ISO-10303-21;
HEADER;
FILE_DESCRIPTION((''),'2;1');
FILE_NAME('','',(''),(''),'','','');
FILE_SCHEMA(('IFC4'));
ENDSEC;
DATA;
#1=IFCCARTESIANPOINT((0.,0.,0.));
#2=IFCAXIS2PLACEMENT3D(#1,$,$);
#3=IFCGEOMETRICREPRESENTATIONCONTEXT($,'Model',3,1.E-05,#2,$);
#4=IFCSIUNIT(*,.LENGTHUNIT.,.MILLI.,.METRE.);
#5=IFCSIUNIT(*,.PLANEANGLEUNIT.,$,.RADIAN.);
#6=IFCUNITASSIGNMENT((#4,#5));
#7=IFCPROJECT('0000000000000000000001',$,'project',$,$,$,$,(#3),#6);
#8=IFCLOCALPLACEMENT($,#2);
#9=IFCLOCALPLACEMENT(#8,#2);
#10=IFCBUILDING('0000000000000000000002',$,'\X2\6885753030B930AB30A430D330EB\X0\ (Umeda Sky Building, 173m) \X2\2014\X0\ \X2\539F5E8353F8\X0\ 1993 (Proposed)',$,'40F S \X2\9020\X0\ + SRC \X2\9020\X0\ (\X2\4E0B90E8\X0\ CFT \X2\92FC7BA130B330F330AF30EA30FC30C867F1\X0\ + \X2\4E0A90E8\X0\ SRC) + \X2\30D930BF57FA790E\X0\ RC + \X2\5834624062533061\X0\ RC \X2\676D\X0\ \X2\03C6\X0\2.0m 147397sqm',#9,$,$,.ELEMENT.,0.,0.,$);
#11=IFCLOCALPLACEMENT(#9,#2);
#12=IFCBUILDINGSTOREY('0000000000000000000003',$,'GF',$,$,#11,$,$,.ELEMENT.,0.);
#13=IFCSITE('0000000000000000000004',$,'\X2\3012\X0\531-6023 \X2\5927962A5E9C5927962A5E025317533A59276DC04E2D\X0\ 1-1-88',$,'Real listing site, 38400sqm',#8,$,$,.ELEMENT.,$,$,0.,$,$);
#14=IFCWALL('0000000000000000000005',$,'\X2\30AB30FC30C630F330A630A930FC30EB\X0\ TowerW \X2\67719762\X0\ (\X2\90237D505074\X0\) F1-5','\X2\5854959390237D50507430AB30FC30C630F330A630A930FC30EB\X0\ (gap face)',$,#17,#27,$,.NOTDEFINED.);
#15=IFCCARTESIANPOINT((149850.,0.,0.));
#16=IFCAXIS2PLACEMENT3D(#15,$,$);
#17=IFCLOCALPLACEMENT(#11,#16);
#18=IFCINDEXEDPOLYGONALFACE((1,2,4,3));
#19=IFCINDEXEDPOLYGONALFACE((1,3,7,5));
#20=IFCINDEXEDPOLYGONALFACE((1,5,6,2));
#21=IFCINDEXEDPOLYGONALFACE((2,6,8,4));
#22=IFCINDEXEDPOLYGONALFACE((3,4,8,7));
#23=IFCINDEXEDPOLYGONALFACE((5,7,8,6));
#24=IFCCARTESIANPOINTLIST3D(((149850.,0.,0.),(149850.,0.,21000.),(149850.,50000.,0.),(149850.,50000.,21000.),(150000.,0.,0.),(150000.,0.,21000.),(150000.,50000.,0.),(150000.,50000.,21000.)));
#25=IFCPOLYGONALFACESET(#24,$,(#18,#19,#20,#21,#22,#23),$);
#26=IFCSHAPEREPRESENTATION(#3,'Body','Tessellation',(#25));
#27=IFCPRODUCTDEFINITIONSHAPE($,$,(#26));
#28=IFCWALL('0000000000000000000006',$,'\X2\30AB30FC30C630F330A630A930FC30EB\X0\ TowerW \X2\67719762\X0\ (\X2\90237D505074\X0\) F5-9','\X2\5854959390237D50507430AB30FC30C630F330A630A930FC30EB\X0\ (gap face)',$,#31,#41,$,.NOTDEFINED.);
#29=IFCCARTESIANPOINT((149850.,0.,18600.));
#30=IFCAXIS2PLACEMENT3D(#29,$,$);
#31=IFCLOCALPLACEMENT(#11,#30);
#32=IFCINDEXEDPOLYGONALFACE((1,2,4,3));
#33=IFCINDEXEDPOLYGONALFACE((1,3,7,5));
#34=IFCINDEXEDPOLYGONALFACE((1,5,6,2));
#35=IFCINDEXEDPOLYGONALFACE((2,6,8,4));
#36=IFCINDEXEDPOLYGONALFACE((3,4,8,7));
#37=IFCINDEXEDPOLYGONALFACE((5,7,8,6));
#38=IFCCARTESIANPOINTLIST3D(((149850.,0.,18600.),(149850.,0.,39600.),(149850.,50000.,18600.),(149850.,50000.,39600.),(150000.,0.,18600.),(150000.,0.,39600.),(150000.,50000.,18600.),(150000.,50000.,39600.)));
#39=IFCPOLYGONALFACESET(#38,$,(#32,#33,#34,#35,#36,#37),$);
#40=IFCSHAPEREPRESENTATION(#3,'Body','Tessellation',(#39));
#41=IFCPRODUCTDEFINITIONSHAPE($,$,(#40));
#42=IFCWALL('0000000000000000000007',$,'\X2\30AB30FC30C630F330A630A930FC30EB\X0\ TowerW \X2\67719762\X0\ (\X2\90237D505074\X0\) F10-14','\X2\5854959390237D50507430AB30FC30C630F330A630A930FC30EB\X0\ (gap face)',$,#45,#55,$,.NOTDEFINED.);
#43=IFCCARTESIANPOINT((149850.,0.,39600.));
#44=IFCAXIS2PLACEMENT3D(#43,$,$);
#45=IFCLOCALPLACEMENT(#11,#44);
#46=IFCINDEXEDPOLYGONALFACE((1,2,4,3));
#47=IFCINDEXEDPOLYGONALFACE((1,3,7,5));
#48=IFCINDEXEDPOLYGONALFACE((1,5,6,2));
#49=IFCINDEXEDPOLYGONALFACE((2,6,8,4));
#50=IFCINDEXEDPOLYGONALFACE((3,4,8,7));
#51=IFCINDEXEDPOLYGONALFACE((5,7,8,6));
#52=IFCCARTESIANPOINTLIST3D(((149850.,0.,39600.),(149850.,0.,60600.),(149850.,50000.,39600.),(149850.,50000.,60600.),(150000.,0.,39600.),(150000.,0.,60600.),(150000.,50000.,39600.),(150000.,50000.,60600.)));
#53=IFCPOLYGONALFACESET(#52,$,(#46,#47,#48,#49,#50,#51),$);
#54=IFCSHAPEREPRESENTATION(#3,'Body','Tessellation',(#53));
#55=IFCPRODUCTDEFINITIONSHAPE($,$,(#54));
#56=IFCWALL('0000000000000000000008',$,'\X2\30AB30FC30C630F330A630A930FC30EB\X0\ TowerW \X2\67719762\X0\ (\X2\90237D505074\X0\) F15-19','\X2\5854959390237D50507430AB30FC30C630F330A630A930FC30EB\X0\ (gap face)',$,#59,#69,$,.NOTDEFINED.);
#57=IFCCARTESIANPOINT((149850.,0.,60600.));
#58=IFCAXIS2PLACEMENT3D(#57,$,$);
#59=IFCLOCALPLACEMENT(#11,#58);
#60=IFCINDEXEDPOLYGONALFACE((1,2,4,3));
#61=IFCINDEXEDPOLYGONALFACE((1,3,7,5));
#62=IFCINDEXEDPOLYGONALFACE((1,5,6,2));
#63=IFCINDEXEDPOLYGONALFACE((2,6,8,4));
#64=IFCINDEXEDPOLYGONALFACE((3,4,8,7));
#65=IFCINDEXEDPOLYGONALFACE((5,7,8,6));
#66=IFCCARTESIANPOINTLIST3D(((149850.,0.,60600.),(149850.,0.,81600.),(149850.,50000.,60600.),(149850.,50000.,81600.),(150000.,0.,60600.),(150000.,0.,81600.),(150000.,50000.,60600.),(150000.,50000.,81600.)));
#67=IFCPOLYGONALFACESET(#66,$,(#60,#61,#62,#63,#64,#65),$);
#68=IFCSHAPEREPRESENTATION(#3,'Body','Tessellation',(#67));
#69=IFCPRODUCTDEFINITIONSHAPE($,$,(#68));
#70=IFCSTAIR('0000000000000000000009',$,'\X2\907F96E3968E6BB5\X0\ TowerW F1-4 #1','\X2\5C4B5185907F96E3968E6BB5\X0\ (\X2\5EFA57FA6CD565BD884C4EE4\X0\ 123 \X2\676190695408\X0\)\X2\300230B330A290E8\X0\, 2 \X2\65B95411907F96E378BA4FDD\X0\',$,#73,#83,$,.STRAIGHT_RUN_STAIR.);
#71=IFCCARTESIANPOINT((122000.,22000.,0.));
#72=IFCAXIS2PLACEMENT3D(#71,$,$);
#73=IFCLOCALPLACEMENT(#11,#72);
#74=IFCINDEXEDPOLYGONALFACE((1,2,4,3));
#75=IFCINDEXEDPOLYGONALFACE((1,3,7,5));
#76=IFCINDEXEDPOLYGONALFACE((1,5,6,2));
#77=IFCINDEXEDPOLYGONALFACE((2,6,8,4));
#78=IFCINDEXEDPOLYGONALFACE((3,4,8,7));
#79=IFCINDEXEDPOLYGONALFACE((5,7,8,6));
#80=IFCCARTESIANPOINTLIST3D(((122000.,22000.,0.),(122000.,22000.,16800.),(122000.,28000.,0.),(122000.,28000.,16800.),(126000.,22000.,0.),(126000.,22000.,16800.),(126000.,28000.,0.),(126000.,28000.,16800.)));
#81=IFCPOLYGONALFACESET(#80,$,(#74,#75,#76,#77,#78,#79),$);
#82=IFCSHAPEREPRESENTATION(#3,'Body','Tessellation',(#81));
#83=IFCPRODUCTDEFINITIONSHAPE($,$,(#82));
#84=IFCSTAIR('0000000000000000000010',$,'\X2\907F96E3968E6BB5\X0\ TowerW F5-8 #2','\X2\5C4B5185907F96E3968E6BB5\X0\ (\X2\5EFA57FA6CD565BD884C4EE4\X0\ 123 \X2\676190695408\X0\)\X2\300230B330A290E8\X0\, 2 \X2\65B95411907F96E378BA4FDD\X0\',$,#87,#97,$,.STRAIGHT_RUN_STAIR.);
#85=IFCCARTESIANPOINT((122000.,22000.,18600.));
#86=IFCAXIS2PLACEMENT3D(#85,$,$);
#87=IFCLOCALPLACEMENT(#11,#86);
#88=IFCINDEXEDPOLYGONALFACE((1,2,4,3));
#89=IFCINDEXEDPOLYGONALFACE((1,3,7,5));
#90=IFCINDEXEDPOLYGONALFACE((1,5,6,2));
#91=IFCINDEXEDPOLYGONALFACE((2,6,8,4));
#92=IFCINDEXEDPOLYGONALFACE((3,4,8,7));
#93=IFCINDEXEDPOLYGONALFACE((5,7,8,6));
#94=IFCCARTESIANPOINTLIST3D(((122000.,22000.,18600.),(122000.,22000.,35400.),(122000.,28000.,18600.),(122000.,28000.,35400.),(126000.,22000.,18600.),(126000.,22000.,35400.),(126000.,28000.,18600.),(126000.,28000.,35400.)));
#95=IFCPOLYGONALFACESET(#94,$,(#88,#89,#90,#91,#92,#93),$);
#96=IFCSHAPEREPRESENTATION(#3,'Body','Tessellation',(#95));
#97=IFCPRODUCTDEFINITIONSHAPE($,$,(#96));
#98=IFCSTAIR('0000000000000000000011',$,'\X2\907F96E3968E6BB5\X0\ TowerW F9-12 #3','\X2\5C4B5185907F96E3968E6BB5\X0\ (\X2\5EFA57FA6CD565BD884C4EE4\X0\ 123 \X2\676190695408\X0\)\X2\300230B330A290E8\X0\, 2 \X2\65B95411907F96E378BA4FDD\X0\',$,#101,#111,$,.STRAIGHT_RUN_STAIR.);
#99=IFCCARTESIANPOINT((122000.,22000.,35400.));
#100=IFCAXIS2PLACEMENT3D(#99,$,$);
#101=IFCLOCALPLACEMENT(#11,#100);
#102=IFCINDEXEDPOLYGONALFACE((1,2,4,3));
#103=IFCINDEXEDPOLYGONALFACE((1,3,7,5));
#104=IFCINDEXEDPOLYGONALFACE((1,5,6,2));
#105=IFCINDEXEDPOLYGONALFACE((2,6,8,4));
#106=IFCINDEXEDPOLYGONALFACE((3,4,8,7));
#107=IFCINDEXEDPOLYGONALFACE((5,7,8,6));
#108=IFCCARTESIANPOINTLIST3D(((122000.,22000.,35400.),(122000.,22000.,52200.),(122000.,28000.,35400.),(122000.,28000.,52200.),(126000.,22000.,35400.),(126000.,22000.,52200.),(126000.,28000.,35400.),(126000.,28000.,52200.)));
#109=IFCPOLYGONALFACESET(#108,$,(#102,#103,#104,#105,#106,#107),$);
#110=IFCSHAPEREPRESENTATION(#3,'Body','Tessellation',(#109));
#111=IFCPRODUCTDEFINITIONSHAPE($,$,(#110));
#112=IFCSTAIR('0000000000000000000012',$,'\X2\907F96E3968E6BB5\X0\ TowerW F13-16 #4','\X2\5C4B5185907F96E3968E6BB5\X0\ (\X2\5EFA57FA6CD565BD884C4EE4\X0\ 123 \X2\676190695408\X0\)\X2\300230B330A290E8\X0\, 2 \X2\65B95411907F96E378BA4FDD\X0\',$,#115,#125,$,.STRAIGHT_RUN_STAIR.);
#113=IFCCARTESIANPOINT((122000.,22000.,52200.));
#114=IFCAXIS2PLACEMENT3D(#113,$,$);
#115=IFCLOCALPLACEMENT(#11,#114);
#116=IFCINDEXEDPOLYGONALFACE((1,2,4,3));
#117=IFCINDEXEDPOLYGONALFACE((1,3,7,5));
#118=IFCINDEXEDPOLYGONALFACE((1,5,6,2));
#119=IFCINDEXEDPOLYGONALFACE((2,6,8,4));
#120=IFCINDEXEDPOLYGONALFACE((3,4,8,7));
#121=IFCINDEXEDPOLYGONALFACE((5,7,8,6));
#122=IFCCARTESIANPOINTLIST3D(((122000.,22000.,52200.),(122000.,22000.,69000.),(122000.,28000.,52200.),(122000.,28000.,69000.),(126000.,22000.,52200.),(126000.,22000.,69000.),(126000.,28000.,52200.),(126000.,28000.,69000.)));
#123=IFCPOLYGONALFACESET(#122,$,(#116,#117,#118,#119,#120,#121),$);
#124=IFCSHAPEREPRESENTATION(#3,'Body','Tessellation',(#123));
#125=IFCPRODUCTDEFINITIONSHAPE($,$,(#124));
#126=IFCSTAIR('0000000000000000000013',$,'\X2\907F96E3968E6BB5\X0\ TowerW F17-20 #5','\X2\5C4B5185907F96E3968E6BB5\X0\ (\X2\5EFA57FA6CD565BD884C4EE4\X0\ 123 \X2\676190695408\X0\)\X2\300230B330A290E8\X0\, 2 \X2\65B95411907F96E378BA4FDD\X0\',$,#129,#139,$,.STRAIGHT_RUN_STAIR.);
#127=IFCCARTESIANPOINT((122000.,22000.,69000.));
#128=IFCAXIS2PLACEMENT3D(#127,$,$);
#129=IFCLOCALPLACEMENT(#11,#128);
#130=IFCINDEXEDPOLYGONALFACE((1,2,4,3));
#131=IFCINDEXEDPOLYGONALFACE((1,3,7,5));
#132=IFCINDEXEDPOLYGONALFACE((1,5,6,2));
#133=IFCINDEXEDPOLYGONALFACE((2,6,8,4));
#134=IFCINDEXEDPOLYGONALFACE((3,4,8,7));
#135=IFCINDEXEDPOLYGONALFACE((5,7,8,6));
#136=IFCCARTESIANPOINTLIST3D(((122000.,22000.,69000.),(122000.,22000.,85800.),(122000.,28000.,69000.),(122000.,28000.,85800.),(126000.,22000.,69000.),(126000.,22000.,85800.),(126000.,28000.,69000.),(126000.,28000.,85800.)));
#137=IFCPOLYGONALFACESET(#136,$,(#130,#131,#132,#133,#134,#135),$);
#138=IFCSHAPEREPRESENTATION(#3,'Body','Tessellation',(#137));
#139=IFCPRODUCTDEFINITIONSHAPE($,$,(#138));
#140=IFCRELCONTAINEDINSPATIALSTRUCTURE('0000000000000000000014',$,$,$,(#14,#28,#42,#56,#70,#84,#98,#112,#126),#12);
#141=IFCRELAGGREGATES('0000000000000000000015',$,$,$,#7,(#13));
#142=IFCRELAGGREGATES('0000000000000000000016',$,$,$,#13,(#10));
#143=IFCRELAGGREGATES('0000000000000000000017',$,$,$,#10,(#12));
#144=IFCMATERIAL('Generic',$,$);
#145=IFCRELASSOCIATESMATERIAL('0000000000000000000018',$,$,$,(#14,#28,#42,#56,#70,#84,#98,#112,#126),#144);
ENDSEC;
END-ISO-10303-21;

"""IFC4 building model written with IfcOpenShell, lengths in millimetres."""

from ifc_helpers import new_model, si_unit, frame, frame_2d, origin, place, context, project, spatial, rectangle, extrude, material, element, save


model = new_model("IFC4")

# Units and contexts
model_context = context("Model", 3, precision=1e-05, world=origin())
ifc_project = project(units=[si_unit("LENGTHUNIT", "METRE", prefix="MILLI"), si_unit("PLANEANGLEUNIT", "RADIAN")], contexts=[model_context])

# Site, building, storey
site_placement = place(None, origin())
site = spatial("IfcSite", under=ifc_project, at=site_placement, Name="〒531-6023 大阪府大阪市北区大淀中 1-1-88", ObjectType="Real listing site, 38400sqm", CompositionType="ELEMENT", RefElevation=0.0)
building_placement = place(site_placement, origin())
building = spatial("IfcBuilding", under=site, at=building_placement, Name="梅田スカイビル (Umeda Sky Building, 173m) — 原広司 1993 (Proposed)", ObjectType="40F S 造 + SRC 造 (下部 CFT 鋼管コンクリート柱 + 上部 SRC) + ベタ基礎 RC + 場所打ち RC 杭 φ2.0m 147397sqm", CompositionType="ELEMENT", ElevationOfRefHeight=0.0, ElevationOfTerrain=0.0)
storey_placement = place(building_placement, origin())
storey = spatial("IfcBuildingStorey", under=building, at=storey_placement, Name="GF", CompositionType="ELEMENT", Elevation=0.0)

# Walls
ifc_material_1 = material(Name="Generic")
wall_1_placement = place(storey_placement, frame((149850.0, 0.0, 0.0)))
element("IfcWall", 1, at=wall_1_placement, inside=storey, material=ifc_material_1, Name="カーテンウォール TowerW 東面 (連結側) F1-5", Description="塔間連結側カーテンウォール (gap face)", PredefinedType="NOTDEFINED", context=model_context, shape_type="SweptSolid", body=[
    extrude(rectangle(XDim=150.0, YDim=50000.0, at=frame_2d((75.0, 25000.0))), frame((149850.0, 0.0, 0.0)), (0.0, 0.0, 1.0), 21000.0),
])
wall_2_placement = place(storey_placement, frame((149850.0, 0.0, 18600.0)))
element("IfcWall", 2, at=wall_2_placement, inside=storey, material=ifc_material_1, Name="カーテンウォール TowerW 東面 (連結側) F5-9", Description="塔間連結側カーテンウォール (gap face)", PredefinedType="NOTDEFINED", context=model_context, shape_type="SweptSolid", body=[
    extrude(rectangle(XDim=150.0, YDim=50000.0, at=frame_2d((75.0, 25000.0))), frame((149850.0, 0.0, 18600.0)), (0.0, 0.0, 1.0), 21000.0),
])
wall_3_placement = place(storey_placement, frame((149850.0, 0.0, 39600.0)))
element("IfcWall", 3, at=wall_3_placement, inside=storey, material=ifc_material_1, Name="カーテンウォール TowerW 東面 (連結側) F10-14", Description="塔間連結側カーテンウォール (gap face)", PredefinedType="NOTDEFINED", context=model_context, shape_type="SweptSolid", body=[
    extrude(rectangle(XDim=150.0, YDim=50000.0, at=frame_2d((75.0, 25000.0))), frame((149850.0, 0.0, 39600.0)), (0.0, 0.0, 1.0), 21000.0),
])
wall_4_placement = place(storey_placement, frame((149850.0, 0.0, 60600.0)))
element("IfcWall", 4, at=wall_4_placement, inside=storey, material=ifc_material_1, Name="カーテンウォール TowerW 東面 (連結側) F15-19", Description="塔間連結側カーテンウォール (gap face)", PredefinedType="NOTDEFINED", context=model_context, shape_type="SweptSolid", body=[
    extrude(rectangle(XDim=150.0, YDim=50000.0, at=frame_2d((75.0, 25000.0))), frame((149850.0, 0.0, 60600.0)), (0.0, 0.0, 1.0), 21000.0),
])

# Stairs
stair_1_placement = place(storey_placement, frame((122000.0, 22000.0, 0.0)))
element("IfcStair", 5, at=stair_1_placement, inside=storey, material=ifc_material_1, Name="避難階段 TowerW F1-4 #1", Description="屋内避難階段 (建基法施行令 123 条適合)。コア部, 2 方向避難確保", PredefinedType="STRAIGHT_RUN_STAIR", context=model_context, shape_type="SweptSolid", body=[
    extrude(rectangle(XDim=4000.0, YDim=6000.0, at=frame_2d((2000.0, 3000.0))), frame((122000.0, 22000.0, 0.0)), (0.0, 0.0, 1.0), 16800.0),
])
stair_2_placement = place(storey_placement, frame((122000.0, 22000.0, 18600.0)))
element("IfcStair", 6, at=stair_2_placement, inside=storey, material=ifc_material_1, Name="避難階段 TowerW F5-8 #2", Description="屋内避難階段 (建基法施行令 123 条適合)。コア部, 2 方向避難確保", PredefinedType="STRAIGHT_RUN_STAIR", context=model_context, shape_type="SweptSolid", body=[
    extrude(rectangle(XDim=4000.0, YDim=6000.0, at=frame_2d((2000.0, 3000.0))), frame((122000.0, 22000.0, 18600.0)), (0.0, 0.0, 1.0), 16800.0),
])
stair_3_placement = place(storey_placement, frame((122000.0, 22000.0, 35400.0)))
element("IfcStair", 7, at=stair_3_placement, inside=storey, material=ifc_material_1, Name="避難階段 TowerW F9-12 #3", Description="屋内避難階段 (建基法施行令 123 条適合)。コア部, 2 方向避難確保", PredefinedType="STRAIGHT_RUN_STAIR", context=model_context, shape_type="SweptSolid", body=[
    extrude(rectangle(XDim=4000.0, YDim=6000.0, at=frame_2d((2000.0, 3000.0))), frame((122000.0, 22000.0, 35400.0)), (0.0, 0.0, 1.0), 16800.0),
])
stair_4_placement = place(storey_placement, frame((122000.0, 22000.0, 52200.0)))
element("IfcStair", 8, at=stair_4_placement, inside=storey, material=ifc_material_1, Name="避難階段 TowerW F13-16 #4", Description="屋内避難階段 (建基法施行令 123 条適合)。コア部, 2 方向避難確保", PredefinedType="STRAIGHT_RUN_STAIR", context=model_context, shape_type="SweptSolid", body=[
    extrude(rectangle(XDim=4000.0, YDim=6000.0, at=frame_2d((2000.0, 3000.0))), frame((122000.0, 22000.0, 52200.0)), (0.0, 0.0, 1.0), 16800.0),
])
stair_5_placement = place(storey_placement, frame((122000.0, 22000.0, 69000.0)))
element("IfcStair", 9, at=stair_5_placement, inside=storey, material=ifc_material_1, Name="避難階段 TowerW F17-20 #5", Description="屋内避難階段 (建基法施行令 123 条適合)。コア部, 2 方向避難確保", PredefinedType="STRAIGHT_RUN_STAIR", context=model_context, shape_type="SweptSolid", body=[
    extrude(rectangle(XDim=4000.0, YDim=6000.0, at=frame_2d((2000.0, 3000.0))), frame((122000.0, 22000.0, 69000.0)), (0.0, 0.0, 1.0), 16800.0),
])

save(model, "model.ifc")
